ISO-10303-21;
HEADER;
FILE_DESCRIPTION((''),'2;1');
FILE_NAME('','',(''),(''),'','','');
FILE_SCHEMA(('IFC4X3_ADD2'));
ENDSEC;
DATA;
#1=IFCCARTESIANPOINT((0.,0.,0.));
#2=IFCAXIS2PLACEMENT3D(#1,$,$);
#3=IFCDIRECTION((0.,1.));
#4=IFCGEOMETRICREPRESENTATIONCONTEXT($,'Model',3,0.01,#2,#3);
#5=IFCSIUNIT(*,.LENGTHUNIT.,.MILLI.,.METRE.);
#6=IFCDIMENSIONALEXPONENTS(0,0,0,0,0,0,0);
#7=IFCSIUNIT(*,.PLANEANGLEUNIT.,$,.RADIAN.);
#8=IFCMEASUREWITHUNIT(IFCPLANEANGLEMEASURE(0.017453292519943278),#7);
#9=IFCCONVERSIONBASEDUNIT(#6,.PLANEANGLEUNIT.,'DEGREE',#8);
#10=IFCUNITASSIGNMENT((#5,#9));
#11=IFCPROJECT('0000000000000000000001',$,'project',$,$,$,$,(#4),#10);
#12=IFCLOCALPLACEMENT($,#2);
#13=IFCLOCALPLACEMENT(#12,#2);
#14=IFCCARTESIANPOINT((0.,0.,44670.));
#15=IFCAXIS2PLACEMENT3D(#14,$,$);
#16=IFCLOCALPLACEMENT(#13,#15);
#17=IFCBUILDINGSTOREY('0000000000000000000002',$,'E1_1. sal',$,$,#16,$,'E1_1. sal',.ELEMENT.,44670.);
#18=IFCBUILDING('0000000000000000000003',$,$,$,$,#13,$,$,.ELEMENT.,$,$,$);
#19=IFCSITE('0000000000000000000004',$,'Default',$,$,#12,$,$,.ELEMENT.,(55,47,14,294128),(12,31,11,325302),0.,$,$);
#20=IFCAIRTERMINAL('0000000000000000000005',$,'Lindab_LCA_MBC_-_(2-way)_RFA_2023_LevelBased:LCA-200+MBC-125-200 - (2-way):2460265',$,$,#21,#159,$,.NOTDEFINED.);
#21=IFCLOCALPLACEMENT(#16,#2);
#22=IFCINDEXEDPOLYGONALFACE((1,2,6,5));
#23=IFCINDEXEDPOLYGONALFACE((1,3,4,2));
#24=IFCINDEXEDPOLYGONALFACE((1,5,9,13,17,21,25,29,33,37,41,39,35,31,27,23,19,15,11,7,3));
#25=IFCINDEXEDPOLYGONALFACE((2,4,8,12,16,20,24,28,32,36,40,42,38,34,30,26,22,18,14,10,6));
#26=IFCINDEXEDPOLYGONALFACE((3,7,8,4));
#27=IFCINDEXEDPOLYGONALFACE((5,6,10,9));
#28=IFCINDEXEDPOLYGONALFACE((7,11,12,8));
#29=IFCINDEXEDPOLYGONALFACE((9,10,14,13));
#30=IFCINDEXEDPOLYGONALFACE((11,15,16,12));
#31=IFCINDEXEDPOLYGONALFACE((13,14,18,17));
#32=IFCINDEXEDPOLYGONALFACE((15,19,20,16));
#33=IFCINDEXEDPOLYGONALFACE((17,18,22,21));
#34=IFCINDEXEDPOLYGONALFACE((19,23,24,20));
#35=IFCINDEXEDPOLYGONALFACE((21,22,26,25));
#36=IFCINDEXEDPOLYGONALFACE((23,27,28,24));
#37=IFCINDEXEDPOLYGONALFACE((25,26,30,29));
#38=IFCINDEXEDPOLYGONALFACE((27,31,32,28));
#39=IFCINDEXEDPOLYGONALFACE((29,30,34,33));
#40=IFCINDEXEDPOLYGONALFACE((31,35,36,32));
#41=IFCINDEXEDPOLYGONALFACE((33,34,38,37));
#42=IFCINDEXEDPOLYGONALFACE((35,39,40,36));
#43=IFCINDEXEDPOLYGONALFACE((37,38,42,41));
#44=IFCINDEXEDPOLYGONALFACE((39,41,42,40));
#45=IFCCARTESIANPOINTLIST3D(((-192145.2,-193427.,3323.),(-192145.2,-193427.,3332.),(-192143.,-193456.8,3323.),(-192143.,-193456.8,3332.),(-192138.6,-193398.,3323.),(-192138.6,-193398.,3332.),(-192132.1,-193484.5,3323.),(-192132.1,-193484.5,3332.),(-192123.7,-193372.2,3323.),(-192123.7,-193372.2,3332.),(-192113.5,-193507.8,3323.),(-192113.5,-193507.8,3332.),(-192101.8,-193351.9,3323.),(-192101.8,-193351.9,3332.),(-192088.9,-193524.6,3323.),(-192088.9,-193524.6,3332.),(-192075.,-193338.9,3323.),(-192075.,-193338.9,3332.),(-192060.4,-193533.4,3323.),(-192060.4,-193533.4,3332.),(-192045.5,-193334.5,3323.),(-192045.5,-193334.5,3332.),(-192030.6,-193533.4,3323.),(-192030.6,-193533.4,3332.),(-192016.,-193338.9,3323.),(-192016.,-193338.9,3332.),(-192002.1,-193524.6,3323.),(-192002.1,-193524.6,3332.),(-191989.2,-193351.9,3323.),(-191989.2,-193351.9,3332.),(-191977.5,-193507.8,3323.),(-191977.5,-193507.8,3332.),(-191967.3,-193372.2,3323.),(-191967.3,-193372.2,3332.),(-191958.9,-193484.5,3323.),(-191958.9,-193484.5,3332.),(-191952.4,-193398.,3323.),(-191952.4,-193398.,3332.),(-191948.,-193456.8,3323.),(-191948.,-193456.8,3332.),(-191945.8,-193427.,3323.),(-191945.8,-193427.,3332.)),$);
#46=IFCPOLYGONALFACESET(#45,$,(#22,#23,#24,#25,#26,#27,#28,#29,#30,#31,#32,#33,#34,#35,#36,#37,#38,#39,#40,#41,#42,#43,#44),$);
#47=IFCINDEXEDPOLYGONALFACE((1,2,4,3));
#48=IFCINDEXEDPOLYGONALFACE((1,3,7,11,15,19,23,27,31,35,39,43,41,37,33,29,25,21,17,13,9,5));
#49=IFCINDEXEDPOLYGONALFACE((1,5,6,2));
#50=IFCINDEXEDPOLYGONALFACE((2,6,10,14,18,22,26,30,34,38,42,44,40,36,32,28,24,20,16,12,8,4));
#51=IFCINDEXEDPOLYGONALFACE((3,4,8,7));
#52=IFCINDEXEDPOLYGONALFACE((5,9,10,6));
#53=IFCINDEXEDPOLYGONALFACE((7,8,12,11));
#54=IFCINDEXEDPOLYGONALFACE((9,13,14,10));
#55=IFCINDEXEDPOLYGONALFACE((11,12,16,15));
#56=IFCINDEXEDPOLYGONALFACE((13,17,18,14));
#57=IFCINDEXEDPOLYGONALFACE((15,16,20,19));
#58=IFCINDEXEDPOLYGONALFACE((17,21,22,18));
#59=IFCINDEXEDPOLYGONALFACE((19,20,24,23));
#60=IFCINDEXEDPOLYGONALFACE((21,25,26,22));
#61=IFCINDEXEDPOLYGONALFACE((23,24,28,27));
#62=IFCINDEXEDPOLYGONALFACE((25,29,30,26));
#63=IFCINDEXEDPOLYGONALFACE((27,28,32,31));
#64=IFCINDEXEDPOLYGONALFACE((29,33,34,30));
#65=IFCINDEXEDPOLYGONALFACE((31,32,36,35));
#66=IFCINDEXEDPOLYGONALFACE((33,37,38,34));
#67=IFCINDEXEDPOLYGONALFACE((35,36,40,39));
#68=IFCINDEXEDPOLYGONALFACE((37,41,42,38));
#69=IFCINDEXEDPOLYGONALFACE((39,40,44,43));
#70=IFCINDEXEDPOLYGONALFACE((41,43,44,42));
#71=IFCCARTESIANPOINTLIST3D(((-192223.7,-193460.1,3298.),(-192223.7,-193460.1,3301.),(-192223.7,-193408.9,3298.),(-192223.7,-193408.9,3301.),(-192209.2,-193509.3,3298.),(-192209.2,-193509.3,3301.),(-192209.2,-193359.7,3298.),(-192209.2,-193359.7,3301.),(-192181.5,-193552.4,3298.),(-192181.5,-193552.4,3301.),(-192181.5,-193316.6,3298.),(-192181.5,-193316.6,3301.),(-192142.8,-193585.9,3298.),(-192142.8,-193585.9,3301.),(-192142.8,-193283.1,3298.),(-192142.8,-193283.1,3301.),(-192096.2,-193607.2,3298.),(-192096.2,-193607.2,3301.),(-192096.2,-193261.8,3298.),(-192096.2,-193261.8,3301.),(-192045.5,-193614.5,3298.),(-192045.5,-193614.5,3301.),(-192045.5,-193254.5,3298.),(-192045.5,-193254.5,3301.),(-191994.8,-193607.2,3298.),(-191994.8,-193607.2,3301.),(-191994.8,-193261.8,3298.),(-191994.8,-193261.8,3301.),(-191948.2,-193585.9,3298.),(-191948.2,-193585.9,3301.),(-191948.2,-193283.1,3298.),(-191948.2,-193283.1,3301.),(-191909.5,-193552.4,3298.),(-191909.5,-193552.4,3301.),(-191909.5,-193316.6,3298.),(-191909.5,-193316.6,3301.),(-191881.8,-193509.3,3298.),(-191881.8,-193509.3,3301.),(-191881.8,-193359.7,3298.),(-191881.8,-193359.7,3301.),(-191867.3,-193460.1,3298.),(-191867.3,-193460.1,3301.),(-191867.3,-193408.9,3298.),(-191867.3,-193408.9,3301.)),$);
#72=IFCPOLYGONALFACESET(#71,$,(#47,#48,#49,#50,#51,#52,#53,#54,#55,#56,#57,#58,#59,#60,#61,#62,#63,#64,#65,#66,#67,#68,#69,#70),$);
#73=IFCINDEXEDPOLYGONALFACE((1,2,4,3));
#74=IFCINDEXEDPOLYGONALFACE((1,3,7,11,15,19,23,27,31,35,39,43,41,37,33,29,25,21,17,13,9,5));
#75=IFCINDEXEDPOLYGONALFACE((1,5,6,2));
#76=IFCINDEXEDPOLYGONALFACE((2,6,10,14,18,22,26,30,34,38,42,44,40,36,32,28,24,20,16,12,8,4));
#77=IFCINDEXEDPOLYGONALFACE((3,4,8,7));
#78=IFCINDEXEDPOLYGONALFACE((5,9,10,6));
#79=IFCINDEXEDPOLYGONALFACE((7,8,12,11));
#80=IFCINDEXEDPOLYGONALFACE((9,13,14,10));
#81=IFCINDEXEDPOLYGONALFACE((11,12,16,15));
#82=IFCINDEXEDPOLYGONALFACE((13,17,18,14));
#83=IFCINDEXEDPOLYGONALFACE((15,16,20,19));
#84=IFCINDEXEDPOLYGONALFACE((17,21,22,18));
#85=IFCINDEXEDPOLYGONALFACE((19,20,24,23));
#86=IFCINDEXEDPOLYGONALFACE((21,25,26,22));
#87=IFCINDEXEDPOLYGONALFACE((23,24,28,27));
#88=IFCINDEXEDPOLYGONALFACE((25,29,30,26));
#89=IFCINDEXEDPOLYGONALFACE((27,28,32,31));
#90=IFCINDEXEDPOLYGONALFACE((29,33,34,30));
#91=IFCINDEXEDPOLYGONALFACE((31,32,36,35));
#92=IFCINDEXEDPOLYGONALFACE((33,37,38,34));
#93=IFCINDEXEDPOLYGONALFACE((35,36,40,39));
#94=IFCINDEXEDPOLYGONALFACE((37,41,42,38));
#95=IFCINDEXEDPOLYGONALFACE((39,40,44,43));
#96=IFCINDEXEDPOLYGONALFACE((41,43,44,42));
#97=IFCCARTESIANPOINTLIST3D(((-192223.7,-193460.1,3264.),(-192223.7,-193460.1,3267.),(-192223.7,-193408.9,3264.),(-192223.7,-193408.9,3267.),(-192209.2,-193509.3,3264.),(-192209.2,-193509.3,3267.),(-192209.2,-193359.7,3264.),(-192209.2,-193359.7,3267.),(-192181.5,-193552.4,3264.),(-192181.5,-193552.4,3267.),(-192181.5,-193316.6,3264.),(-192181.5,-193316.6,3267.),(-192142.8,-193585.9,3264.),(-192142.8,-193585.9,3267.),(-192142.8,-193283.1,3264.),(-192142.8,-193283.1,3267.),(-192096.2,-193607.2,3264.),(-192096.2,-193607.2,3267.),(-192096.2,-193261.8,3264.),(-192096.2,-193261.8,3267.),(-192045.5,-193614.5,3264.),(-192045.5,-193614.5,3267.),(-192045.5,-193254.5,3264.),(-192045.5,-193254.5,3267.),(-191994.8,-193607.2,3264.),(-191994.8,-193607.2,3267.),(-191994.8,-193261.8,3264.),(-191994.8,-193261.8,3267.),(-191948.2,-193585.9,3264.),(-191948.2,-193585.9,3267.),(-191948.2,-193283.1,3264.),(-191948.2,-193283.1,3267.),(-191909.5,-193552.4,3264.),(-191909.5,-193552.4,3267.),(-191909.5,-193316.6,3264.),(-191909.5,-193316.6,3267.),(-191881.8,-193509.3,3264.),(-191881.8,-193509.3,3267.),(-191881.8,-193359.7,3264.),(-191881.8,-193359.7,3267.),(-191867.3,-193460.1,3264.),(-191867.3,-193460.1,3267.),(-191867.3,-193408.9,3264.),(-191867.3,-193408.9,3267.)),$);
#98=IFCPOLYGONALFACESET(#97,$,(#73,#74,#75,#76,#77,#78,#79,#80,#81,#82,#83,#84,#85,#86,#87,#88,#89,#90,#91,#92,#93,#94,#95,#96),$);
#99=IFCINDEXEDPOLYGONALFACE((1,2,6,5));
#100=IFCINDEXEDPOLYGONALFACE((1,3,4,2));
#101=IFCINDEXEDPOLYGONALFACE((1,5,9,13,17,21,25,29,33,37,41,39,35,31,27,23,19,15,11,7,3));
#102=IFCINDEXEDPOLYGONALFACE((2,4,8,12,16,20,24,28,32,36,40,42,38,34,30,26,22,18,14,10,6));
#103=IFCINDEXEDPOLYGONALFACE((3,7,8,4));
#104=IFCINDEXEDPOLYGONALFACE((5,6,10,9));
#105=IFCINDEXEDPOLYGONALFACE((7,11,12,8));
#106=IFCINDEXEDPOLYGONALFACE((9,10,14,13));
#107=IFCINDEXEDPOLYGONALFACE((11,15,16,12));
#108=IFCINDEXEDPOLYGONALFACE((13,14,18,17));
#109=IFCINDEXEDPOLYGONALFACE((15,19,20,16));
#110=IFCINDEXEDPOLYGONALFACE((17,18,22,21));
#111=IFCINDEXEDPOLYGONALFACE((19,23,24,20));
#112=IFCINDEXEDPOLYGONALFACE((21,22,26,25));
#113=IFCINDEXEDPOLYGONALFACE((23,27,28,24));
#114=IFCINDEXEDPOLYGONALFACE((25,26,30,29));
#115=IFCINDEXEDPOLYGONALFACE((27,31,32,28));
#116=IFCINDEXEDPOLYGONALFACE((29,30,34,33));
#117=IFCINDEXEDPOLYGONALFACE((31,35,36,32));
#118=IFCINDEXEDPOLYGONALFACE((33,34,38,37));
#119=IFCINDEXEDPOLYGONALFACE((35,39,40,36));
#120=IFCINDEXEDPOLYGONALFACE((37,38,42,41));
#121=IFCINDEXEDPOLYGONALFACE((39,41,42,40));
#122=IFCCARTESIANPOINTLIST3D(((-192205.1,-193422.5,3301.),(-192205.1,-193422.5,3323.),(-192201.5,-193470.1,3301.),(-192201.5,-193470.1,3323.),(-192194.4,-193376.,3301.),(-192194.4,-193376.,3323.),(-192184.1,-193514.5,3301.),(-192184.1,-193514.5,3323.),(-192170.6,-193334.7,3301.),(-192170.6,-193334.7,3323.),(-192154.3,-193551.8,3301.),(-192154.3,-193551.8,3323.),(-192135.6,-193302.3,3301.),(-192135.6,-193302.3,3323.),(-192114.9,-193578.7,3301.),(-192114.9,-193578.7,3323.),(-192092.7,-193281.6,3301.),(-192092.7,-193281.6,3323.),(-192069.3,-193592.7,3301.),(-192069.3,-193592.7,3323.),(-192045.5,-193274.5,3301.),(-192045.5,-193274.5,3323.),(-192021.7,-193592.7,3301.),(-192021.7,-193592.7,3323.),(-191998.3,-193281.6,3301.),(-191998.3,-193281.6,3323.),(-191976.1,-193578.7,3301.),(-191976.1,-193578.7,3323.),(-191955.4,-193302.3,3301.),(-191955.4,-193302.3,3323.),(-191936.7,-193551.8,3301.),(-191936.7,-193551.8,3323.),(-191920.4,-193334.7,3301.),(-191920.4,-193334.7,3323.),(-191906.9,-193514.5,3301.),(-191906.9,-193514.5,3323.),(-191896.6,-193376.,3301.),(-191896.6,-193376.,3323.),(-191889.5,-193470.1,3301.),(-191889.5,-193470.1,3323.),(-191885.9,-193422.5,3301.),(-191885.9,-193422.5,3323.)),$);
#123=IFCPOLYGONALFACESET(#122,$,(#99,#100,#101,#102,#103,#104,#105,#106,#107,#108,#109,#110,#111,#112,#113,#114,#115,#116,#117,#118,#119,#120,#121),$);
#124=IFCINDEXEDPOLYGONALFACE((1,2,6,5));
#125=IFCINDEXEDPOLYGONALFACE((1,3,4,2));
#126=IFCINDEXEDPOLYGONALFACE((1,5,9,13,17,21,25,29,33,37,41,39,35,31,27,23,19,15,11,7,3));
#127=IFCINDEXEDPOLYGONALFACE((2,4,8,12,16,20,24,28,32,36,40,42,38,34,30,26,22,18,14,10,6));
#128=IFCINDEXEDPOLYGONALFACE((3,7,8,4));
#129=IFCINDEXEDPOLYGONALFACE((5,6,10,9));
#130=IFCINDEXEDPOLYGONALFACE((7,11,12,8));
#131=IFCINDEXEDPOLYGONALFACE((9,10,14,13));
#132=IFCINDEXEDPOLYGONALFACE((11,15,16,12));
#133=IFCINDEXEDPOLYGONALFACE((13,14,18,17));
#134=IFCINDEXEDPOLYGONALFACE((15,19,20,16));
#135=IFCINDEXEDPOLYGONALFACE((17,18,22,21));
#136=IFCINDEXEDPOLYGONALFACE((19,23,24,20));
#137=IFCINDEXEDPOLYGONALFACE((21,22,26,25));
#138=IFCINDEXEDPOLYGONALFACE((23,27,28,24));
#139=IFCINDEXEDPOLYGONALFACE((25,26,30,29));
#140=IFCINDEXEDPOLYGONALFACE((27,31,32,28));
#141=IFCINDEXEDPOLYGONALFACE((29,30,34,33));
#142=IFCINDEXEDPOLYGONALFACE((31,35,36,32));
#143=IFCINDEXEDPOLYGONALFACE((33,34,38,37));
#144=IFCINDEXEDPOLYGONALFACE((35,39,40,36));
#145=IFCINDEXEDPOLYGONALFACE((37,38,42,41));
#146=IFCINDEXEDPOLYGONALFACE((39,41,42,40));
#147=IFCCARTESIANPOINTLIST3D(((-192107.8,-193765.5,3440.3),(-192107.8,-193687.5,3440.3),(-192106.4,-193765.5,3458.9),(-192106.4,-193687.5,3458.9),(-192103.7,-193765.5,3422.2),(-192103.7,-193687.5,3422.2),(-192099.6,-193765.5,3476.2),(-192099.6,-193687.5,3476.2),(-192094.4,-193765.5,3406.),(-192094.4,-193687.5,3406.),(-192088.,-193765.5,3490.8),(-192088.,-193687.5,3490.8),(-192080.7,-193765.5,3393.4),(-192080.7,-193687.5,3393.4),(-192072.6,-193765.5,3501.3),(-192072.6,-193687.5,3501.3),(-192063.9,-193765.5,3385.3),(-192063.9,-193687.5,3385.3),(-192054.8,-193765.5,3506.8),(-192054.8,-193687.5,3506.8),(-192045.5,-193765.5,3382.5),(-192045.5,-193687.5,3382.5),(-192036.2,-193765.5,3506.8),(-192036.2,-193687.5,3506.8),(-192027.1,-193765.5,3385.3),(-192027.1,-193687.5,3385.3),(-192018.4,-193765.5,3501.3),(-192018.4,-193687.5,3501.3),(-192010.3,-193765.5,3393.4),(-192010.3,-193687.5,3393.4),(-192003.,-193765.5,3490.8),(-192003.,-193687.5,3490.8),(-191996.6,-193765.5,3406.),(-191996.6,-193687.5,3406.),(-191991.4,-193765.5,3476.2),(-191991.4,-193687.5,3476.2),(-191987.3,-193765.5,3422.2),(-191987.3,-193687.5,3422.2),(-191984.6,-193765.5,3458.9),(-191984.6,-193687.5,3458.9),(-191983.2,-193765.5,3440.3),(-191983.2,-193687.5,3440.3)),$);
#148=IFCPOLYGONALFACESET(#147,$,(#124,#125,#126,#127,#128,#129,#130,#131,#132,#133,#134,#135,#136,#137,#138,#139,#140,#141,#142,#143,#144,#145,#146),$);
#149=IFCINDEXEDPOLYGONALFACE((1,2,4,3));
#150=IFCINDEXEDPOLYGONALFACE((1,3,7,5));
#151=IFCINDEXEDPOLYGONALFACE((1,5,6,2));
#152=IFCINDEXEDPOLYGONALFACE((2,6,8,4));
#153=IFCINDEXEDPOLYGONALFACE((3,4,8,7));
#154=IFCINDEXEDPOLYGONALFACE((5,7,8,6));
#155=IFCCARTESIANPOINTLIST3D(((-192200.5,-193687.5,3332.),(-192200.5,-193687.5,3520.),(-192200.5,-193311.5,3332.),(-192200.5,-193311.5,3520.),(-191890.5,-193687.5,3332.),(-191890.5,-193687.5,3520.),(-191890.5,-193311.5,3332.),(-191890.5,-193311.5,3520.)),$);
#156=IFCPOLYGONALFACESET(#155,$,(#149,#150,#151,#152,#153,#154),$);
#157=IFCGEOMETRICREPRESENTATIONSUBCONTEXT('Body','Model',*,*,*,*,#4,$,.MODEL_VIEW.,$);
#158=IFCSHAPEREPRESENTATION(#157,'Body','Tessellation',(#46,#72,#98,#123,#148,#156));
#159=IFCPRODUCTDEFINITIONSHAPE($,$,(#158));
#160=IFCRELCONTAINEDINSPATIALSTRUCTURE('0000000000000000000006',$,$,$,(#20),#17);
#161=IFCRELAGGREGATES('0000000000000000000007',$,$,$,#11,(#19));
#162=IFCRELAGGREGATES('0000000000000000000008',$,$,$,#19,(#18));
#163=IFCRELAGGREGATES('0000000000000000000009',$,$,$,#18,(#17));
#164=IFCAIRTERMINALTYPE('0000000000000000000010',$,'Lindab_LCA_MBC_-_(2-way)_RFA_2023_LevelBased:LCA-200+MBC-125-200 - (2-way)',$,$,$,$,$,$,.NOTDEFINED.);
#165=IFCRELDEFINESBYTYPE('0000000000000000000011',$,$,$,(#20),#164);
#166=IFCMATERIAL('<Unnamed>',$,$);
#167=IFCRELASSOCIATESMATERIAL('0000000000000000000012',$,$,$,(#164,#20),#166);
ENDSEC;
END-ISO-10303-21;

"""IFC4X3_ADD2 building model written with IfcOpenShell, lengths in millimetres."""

from ifc_helpers import new_model, entity, si_unit, converted_unit, direction, frame, frame_2d, origin, origin_2d_with_axis, place, context, subcontext, project, spatial, rectangle, circle, extrude, source, transform, mapped, material, type_object, type_shapes, element, save


model = new_model("IFC4X3_ADD2")

# Units and contexts
model_context = context("Model", 3, precision=0.01, world=origin(), true_north=direction((0.0, 1.0)))
body_context = subcontext(model_context, "Body", "Model", "MODEL_VIEW")
ifc_project = project(units=[si_unit("LENGTHUNIT", "METRE", prefix="MILLI"), converted_unit("PLANEANGLEUNIT", "DEGREE", entity("IfcPlaneAngleMeasure", 0.017453292519943278), si_unit("PLANEANGLEUNIT", "RADIAN"), dimensions=[0, 0, 0, 0, 0, 0, 0])], contexts=[model_context])

# Site, building, storey
site_placement = place(None, origin())
site = spatial("IfcSite", under=ifc_project, at=site_placement, Name="Default", CompositionType="ELEMENT", RefLatitude=(55, 47, 14, 294128), RefLongitude=(12, 31, 11, 325302), RefElevation=0.0)
building_placement = place(site_placement, origin())
building = spatial("IfcBuilding", under=site, at=building_placement, CompositionType="ELEMENT")
storey_placement = place(building_placement, frame((0.0, 0.0, 44670.0)))
storey = spatial("IfcBuildingStorey", under=building, at=storey_placement, Name="E1_1. sal", LongName="E1_1. sal", CompositionType="ELEMENT", Elevation=44670.0)

# Air terminal
ifc_material_1 = material(Name="<Unnamed>")
air_terminal_type = type_object("IfcAirTerminalType", Name="Lindab_LCA_MBC_-_(2-way)_RFA_2023_LevelBased:LCA-200+MBC-125-200 - (2-way)", PredefinedType="NOTDEFINED", material=ifc_material_1)
shared_shape_1 = source(origin(), body_context, "Body", "SweptSolid", [
    extrude(circle(Radius=100.0, at=frame_2d((0.0, 0.0), x_axis=(1.0, 0.0))), frame((0.0, 0.0, 22.0)), (0.0, 0.0, 1.0), 9.0),
    extrude(circle(Radius=180.0, at=frame_2d((0.0, 0.0), x_axis=(1.0, 0.0))), frame((0.0, 0.0, -3.0)), (0.0, 0.0, 1.0), 3.0),
    extrude(circle(Radius=180.0, at=frame_2d((0.0, 0.0), x_axis=(1.0, 0.0))), frame((0.0, 0.0, -37.0)), (0.0, 0.0, 1.0), 3.0),
    extrude(circle(Radius=160.0, at=frame_2d((0.0, 0.0), x_axis=(1.0, 0.0))), origin(), (0.0, 0.0, 1.0), 22.0),
    extrude(circle(Radius=62.5, at=frame_2d((0.0, 0.0), x_axis=(1.0, 0.0))), frame((-331.0, 0.0, 144.0), z_axis=(1.0, 0.0, 0.0), x_axis=(0.0, 0.0, -1.0)), (0.0, 0.0, 1.0), 78.0),
    extrude(rectangle(XDim=310.0, YDim=376.0, at=origin_2d_with_axis()), frame((-65.0, 0.0, 31.0), z_axis=(0.0, 0.0, 1.0), x_axis=(0.0, -1.0, 0.0)), (0.0, 0.0, 1.0), 188.0),
])
type_shapes(air_terminal_type, [shared_shape_1])
for number, where, z_axis, x_axis, name in (
    (1, (-192045.5, -193434.5, 3301.0), (0.0, 0.0, 1.0), (0.0, 1.0, 0.0), "Lindab_LCA_MBC_-_(2-way)_RFA_2023_LevelBased:LCA-200+MBC-125-200 - (2-way):2460265"),
):
    element("IfcAirTerminal", number, at=place(storey_placement, frame(where, z_axis=z_axis, x_axis=x_axis)), inside=storey, type_object=air_terminal_type, material=ifc_material_1, Name=name, PredefinedType="NOTDEFINED", context=body_context, shape_type="MappedRepresentation", body=[
        mapped(shared_shape_1, transform((0.0, 0.0, 0.0), scale=1.0)),
    ])

save(model, "model.ifc")
